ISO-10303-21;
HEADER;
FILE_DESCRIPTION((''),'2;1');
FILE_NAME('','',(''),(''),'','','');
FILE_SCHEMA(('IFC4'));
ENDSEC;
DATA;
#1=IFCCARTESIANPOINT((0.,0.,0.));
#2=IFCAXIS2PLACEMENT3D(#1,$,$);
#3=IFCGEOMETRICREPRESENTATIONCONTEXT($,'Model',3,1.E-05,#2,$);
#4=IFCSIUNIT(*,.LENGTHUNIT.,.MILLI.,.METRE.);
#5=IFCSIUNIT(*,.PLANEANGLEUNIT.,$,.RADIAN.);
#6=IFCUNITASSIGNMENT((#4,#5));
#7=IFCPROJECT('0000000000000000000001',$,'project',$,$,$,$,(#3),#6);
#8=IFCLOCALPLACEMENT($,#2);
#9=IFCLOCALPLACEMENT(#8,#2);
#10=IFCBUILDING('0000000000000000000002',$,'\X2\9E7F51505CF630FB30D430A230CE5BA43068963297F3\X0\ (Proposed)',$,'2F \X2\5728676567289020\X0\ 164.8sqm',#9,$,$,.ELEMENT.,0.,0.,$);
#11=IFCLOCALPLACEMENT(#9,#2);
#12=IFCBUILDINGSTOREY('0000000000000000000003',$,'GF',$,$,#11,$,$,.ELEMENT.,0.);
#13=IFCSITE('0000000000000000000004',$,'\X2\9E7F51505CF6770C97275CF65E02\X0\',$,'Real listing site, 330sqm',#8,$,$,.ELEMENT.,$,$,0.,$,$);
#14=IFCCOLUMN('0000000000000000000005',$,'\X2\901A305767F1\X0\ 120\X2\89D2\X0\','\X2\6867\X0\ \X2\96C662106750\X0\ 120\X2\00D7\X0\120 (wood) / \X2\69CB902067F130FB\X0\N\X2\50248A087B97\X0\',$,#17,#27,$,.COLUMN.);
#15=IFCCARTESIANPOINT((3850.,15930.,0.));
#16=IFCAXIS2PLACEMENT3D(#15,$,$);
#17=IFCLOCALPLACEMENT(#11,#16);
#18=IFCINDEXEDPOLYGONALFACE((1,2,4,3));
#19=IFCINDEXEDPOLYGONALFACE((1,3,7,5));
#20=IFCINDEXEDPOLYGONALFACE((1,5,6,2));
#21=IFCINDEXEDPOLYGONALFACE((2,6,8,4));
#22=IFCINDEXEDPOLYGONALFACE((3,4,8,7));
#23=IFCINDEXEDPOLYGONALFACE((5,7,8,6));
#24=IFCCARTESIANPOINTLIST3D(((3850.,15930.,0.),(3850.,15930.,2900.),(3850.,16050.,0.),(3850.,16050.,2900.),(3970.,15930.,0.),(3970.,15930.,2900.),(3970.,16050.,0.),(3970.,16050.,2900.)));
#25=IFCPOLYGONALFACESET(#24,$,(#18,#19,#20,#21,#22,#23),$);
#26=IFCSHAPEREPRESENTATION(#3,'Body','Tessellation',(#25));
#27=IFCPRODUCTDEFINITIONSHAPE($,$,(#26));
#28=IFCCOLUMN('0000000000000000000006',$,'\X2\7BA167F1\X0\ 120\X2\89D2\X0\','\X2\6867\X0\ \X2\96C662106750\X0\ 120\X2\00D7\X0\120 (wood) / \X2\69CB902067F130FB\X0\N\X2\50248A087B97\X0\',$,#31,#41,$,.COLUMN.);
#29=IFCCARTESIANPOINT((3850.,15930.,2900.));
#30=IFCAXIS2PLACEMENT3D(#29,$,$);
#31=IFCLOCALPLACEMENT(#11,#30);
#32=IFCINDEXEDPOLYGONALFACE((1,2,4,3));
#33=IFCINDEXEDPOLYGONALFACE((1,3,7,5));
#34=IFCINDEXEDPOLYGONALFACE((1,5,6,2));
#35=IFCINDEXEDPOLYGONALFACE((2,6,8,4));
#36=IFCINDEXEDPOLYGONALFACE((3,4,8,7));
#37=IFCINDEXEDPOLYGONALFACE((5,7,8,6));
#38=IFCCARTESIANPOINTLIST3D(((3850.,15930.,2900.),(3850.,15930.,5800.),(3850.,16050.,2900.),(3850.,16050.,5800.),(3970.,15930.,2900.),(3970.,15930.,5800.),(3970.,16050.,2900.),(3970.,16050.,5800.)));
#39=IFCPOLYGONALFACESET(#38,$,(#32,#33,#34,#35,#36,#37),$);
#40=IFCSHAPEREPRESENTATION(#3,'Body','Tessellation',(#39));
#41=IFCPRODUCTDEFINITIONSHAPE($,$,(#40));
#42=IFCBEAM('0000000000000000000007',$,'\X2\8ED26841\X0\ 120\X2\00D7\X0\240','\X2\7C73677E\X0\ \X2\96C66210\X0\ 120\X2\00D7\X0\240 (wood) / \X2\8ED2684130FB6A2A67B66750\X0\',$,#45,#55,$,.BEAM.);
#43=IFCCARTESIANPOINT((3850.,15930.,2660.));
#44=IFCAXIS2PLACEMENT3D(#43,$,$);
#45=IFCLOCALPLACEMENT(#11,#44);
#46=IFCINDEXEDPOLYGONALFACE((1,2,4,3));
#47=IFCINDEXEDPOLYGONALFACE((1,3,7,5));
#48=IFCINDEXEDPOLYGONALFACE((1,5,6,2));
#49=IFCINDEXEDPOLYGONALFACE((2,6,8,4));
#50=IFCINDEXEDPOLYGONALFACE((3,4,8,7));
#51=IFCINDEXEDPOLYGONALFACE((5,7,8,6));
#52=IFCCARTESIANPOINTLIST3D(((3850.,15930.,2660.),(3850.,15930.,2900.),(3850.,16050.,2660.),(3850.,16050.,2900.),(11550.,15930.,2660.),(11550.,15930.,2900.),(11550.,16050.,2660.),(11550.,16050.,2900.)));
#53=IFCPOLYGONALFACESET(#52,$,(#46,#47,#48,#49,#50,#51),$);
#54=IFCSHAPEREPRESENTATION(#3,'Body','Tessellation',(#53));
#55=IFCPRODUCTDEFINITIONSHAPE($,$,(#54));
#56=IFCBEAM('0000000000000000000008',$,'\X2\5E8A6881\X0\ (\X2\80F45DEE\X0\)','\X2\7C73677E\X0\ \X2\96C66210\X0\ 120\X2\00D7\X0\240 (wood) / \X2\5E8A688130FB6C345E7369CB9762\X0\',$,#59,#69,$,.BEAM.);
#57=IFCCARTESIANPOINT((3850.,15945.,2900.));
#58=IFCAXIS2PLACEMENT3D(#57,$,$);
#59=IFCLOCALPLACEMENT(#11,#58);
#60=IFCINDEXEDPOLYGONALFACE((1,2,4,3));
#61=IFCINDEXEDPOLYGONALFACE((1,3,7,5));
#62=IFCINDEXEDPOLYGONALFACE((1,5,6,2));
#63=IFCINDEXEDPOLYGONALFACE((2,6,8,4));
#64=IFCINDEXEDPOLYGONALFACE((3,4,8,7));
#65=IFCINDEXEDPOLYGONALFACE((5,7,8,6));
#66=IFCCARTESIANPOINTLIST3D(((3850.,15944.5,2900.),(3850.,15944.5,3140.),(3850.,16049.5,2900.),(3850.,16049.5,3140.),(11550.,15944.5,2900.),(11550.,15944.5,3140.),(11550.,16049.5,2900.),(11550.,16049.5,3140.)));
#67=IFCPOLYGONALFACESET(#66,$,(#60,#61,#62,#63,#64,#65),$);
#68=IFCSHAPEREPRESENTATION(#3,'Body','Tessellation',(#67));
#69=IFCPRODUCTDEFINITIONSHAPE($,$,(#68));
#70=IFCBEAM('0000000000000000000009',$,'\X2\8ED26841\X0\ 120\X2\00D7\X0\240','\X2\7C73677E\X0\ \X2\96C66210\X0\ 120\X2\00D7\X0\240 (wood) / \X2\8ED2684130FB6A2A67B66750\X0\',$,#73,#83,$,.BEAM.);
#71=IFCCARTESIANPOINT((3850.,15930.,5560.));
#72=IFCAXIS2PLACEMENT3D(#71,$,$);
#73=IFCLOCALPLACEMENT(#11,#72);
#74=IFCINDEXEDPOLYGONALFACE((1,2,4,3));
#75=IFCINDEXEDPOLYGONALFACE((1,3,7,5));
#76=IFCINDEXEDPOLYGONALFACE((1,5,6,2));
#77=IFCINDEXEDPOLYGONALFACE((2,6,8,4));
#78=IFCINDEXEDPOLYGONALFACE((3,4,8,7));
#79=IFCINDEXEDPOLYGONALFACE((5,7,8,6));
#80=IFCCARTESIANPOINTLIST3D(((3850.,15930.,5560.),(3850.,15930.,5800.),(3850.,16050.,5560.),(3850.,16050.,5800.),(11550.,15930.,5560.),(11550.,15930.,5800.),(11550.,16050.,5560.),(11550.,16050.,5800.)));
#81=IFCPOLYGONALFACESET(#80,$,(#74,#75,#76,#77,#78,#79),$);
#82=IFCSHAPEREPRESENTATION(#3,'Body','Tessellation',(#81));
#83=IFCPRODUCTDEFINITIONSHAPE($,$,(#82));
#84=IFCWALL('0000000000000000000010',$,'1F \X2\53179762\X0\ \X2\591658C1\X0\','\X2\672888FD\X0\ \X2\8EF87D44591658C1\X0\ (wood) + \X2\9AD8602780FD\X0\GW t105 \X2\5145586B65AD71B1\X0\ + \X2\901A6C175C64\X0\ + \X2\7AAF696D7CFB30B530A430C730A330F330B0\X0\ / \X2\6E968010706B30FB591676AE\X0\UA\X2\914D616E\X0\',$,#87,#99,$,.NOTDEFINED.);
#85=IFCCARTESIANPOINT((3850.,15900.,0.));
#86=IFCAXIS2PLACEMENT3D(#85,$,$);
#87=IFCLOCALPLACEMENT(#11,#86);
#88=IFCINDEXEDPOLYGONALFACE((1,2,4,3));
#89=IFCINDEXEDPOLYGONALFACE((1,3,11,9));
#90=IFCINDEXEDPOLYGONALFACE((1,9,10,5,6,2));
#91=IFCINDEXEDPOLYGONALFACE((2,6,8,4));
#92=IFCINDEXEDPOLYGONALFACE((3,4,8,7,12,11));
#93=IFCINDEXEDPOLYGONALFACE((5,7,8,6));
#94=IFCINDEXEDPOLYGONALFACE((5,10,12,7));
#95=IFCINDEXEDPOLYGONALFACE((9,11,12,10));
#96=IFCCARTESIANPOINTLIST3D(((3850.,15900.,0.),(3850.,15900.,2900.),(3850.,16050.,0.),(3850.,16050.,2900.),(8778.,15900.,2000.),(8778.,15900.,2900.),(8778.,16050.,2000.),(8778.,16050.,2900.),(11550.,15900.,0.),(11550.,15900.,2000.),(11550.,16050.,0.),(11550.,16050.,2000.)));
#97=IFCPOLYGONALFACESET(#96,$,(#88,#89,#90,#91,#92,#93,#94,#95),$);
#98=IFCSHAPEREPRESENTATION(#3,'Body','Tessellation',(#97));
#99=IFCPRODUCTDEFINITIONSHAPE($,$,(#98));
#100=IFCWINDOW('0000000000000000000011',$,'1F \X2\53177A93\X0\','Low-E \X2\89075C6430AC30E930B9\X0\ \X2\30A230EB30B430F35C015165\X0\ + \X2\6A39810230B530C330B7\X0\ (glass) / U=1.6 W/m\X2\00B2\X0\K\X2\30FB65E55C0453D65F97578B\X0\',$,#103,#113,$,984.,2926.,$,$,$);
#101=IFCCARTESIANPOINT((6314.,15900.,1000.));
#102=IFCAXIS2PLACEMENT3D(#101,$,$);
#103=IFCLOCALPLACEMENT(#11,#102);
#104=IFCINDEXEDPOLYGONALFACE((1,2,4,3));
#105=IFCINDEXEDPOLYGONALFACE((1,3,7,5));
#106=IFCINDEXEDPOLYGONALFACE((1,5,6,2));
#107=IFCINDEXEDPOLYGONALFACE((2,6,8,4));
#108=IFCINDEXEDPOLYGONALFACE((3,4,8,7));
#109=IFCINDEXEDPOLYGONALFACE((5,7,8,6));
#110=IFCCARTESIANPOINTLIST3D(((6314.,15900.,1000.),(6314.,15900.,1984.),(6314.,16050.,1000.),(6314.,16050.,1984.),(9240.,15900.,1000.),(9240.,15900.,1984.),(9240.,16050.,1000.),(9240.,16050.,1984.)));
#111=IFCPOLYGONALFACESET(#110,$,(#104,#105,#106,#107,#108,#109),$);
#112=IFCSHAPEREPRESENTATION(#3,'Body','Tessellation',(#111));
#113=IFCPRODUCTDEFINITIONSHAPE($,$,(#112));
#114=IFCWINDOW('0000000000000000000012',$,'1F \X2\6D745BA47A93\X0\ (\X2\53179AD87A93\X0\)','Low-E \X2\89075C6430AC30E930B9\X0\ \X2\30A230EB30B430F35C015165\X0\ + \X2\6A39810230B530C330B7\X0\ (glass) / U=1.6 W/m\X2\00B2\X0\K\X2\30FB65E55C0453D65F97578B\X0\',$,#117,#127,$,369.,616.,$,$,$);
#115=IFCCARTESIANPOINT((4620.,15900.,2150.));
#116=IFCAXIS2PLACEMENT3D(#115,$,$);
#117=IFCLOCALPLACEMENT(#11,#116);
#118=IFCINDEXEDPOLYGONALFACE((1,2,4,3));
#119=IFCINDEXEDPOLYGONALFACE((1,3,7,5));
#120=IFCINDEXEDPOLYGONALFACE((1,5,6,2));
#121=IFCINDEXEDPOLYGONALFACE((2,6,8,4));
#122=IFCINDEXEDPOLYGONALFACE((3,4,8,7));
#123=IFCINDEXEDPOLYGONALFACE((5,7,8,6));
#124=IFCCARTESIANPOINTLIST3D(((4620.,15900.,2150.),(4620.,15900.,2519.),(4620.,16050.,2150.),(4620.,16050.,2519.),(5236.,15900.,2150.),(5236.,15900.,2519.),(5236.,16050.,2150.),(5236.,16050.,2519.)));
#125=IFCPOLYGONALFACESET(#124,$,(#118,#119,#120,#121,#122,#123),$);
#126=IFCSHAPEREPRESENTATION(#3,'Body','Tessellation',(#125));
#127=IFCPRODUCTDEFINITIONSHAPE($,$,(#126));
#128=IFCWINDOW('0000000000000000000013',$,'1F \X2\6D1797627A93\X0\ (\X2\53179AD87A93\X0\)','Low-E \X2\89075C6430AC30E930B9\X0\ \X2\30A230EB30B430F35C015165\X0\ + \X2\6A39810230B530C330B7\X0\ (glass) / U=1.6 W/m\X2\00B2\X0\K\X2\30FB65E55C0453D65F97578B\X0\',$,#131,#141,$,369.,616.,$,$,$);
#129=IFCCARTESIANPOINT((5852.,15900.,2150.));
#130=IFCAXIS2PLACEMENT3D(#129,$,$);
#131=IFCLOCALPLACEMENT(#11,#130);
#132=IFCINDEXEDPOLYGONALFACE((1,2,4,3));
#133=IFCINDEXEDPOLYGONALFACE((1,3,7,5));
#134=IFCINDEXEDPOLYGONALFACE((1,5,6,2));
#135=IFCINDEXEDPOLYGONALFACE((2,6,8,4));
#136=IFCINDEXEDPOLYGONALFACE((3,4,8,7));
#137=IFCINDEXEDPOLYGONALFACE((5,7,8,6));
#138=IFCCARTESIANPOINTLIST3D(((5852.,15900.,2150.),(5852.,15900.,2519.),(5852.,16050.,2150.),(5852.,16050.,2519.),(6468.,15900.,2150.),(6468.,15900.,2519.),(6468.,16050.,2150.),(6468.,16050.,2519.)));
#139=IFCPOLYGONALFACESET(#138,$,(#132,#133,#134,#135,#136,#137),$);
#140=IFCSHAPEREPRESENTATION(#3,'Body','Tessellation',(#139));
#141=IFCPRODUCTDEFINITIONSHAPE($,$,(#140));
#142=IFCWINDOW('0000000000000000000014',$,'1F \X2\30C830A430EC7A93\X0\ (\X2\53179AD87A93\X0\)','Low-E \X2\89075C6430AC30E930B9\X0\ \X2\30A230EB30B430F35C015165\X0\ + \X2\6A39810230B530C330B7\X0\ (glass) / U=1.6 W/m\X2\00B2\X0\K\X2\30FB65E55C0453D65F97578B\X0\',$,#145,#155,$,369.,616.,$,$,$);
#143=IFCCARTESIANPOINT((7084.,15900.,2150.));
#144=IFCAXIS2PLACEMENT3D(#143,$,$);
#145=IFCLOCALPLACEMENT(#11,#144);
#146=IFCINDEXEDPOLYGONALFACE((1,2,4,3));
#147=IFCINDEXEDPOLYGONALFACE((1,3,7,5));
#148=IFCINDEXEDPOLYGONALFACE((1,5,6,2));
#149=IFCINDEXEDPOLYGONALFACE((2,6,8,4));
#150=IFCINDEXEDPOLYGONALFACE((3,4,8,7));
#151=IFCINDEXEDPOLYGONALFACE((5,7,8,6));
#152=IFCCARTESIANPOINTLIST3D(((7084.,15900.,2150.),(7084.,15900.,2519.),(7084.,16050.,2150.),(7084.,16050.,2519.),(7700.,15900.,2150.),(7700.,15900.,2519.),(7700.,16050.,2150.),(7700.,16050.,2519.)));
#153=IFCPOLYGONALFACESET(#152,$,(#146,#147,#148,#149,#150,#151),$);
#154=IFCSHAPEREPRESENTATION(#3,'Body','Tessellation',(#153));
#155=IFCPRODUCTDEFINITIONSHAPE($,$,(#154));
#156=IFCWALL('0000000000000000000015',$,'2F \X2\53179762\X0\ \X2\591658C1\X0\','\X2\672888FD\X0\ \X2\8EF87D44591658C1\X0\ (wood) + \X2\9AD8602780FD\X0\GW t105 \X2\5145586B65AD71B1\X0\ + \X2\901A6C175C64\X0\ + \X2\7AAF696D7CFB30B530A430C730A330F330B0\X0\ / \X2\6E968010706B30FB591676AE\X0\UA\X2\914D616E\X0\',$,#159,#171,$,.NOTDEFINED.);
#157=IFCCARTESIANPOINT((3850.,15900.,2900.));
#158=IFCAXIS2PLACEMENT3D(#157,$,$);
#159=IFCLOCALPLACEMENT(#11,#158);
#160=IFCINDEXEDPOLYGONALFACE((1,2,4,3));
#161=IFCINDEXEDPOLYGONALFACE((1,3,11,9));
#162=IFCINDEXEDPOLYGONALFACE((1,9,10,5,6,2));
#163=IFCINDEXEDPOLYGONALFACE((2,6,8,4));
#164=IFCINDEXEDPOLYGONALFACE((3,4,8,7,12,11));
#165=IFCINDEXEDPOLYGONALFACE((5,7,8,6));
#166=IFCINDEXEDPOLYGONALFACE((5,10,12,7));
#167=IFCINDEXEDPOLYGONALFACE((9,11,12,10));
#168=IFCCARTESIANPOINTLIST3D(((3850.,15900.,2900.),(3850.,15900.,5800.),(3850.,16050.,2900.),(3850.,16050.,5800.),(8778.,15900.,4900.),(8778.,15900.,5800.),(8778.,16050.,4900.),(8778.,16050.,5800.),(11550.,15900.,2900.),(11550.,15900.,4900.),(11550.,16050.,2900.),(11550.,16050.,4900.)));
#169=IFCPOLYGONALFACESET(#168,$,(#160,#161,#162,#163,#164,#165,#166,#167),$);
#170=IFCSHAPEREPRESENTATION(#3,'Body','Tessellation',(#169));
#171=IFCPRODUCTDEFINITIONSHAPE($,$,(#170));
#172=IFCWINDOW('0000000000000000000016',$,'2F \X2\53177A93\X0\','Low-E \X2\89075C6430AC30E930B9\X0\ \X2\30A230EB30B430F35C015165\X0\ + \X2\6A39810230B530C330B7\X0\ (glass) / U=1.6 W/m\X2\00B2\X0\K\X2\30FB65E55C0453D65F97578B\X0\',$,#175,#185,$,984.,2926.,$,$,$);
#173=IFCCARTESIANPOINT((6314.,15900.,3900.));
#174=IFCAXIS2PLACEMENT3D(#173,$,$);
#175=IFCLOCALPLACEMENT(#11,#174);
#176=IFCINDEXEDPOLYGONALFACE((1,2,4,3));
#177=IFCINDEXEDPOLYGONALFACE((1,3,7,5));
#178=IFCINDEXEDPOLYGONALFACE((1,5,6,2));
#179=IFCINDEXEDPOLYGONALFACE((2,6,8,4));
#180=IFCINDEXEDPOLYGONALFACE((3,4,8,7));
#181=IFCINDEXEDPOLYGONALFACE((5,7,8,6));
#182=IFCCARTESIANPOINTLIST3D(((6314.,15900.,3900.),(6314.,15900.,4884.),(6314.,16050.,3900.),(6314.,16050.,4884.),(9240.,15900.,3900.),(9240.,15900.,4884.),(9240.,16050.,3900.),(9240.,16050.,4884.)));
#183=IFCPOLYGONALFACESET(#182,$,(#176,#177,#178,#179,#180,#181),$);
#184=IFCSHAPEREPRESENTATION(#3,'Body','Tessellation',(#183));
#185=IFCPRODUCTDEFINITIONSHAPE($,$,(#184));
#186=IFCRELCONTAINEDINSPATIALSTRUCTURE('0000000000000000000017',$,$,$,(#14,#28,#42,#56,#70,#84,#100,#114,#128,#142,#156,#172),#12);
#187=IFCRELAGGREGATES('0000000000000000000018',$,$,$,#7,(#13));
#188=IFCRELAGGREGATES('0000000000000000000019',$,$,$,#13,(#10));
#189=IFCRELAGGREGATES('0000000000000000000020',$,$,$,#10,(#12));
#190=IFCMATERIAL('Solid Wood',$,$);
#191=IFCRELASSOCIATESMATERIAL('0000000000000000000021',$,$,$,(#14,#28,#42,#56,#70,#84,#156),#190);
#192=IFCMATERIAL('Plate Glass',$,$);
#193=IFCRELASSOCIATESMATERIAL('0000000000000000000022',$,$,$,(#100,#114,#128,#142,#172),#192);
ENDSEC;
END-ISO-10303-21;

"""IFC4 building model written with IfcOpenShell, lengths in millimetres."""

from ifc_helpers import new_model, si_unit, frame, frame_2d, origin, place, context, project, spatial, rectangle, extrude, material, element, fill, save


model = new_model("IFC4")

# Units and contexts
model_context = context("Model", 3, precision=1e-05, world=origin())
ifc_project = project(units=[si_unit("LENGTHUNIT", "METRE", prefix="MILLI"), si_unit("PLANEANGLEUNIT", "RADIAN")], contexts=[model_context])

# Site, building, storey
site_placement = place(None, origin())
site = spatial("IfcSite", under=ifc_project, at=site_placement, Name="鹿児島県霧島市", ObjectType="Real listing site, 330sqm", CompositionType="ELEMENT", RefElevation=0.0)
building_placement = place(site_placement, origin())
building = spatial("IfcBuilding", under=site, at=building_placement, Name="鹿児島・ピアノ室と防音 (Proposed)", ObjectType="2F 在来木造 164.8sqm", CompositionType="ELEMENT", ElevationOfRefHeight=0.0, ElevationOfTerrain=0.0)
storey_placement = place(building_placement, origin())
storey = spatial("IfcBuildingStorey", under=building, at=storey_placement, Name="GF", CompositionType="ELEMENT", Elevation=0.0)

# Columns
ifc_material_1 = material(Name="Solid Wood")
column_1_placement = place(storey_placement, frame((3850.0, 15930.0, 0.0)))
element("IfcColumn", 1, at=column_1_placement, inside=storey, material=ifc_material_1, Name="通し柱 120角", Description="桧 集成材 120×120 (wood) / 構造柱・N値計算", PredefinedType="COLUMN", context=model_context, shape_type="SweptSolid", body=[
    extrude(rectangle(XDim=120.0, YDim=120.0, at=frame_2d((60.0, 60.0))), frame((3850.0, 15930.0, 0.0)), (0.0, 0.0, 1.0), 2900.0),
])
column_2_placement = place(storey_placement, frame((3850.0, 15930.0, 2900.0)))
element("IfcColumn", 2, at=column_2_placement, inside=storey, material=ifc_material_1, Name="管柱 120角", Description="桧 集成材 120×120 (wood) / 構造柱・N値計算", PredefinedType="COLUMN", context=model_context, shape_type="SweptSolid", body=[
    extrude(rectangle(XDim=120.0, YDim=120.0, at=frame_2d((60.0, 60.0))), frame((3850.0, 15930.0, 2900.0)), (0.0, 0.0, 1.0), 2900.0),
])

# Beams
beam_1_placement = place(storey_placement, frame((3850.0, 15930.0, 2660.0)))
element("IfcBeam", 3, at=beam_1_placement, inside=storey, material=ifc_material_1, Name="軒桁 120×240", Description="米松 集成 120×240 (wood) / 軒桁・横架材", PredefinedType="BEAM", context=model_context, shape_type="SweptSolid", body=[
    extrude(rectangle(XDim=7700.0, YDim=120.0, at=frame_2d((3850.0, 60.0))), frame((3850.0, 15930.0, 2660.0)), (0.0, 0.0, 1.0), 240.0),
])
beam_2_placement = place(storey_placement, frame((3850.0, 15945.0, 2900.0)))
element("IfcBeam", 4, at=beam_2_placement, inside=storey, material=ifc_material_1, Name="床梁 (胴差)", Description="米松 集成 120×240 (wood) / 床梁・水平構面", PredefinedType="BEAM", context=model_context, shape_type="SweptSolid", body=[
    extrude(rectangle(XDim=7700.0, YDim=105.0, at=frame_2d((3850.0, 52.0))), frame((3850.0, 15945.0, 2900.0)), (0.0, 0.0, 1.0), 240.0),
])
beam_3_placement = place(storey_placement, frame((3850.0, 15930.0, 5560.0)))
element("IfcBeam", 5, at=beam_3_placement, inside=storey, material=ifc_material_1, Name="軒桁 120×240", Description="米松 集成 120×240 (wood) / 軒桁・横架材", PredefinedType="BEAM", context=model_context, shape_type="SweptSolid", body=[
    extrude(rectangle(XDim=7700.0, YDim=120.0, at=frame_2d((3850.0, 60.0))), frame((3850.0, 15930.0, 5560.0)), (0.0, 0.0, 1.0), 240.0),
])

# Wall, openings, windows
wall_1_placement = place(storey_placement, frame((3850.0, 15900.0, 0.0)))
wall_1 = element("IfcWall", 6, at=wall_1_placement, inside=storey, material=ifc_material_1, Name="1F 北面 外壁", Description="木製 軸組外壁 (wood) + 高性能GW t105 充填断熱 + 通気層 + 窯業系サイディング / 準耐火・外皮UA配慮", PredefinedType="NOTDEFINED", context=model_context, shape_type="SweptSolid", body=[
    extrude(rectangle(XDim=7700.0, YDim=150.0, at=frame_2d((3850.0, 75.0))), frame((3850.0, 15900.0, 0.0)), (0.0, 0.0, 1.0), 2900.0),
])
opening_1_placement = place(storey_placement, frame((6314.0, 15900.0, 1000.0)))
opening_1 = element("IfcOpeningElement", 7, at=opening_1_placement, cuts=wall_1, PredefinedType="NOTDEFINED", context=model_context, shape_type="SweptSolid", body=[
    extrude(rectangle(XDim=2926.0, YDim=150.0, at=frame_2d((1463.0, 75.0))), frame((6314.0, 15900.0, 1000.0)), (0.0, 0.0, 1.0), 984.0),
])
opening_2_placement = place(storey_placement, frame((4620.0, 15900.0, 2150.0)))
opening_2 = element("IfcOpeningElement", 8, at=opening_2_placement, cuts=wall_1, PredefinedType="NOTDEFINED", context=model_context, shape_type="SweptSolid", body=[
    extrude(rectangle(XDim=616.0, YDim=150.0, at=frame_2d((308.0, 75.0))), frame((4620.0, 15900.0, 2150.0)), (0.0, 0.0, 1.0), 369.0),
])
opening_3_placement = place(storey_placement, frame((5852.0, 15900.0, 2150.0)))
opening_3 = element("IfcOpeningElement", 9, at=opening_3_placement, cuts=wall_1, PredefinedType="NOTDEFINED", context=model_context, shape_type="SweptSolid", body=[
    extrude(rectangle(XDim=616.0, YDim=150.0, at=frame_2d((308.0, 75.0))), frame((5852.0, 15900.0, 2150.0)), (0.0, 0.0, 1.0), 369.0),
])
opening_4_placement = place(storey_placement, frame((7084.0, 15900.0, 2150.0)))
opening_4 = element("IfcOpeningElement", 10, at=opening_4_placement, cuts=wall_1, PredefinedType="NOTDEFINED", context=model_context, shape_type="SweptSolid", body=[
    extrude(rectangle(XDim=616.0, YDim=150.0, at=frame_2d((308.0, 75.0))), frame((7084.0, 15900.0, 2150.0)), (0.0, 0.0, 1.0), 369.0),
])
ifc_material_2 = material(Name="Plate Glass")
window_1_placement = place(storey_placement, frame((6314.0, 15900.0, 1000.0)))
window_1 = element("IfcWindow", 11, at=window_1_placement, inside=storey, material=ifc_material_2, Name="1F 北窓", Description="Low-E 複層ガラス アルゴン封入 + 樹脂サッシ (glass) / U=1.6 W/m²K・日射取得型", OverallHeight=984.0, OverallWidth=2926.0, context=model_context, shape_type="SweptSolid", body=[
    extrude(rectangle(XDim=2926.0, YDim=150.0, at=frame_2d((1463.0, 75.0))), frame((6314.0, 15900.0, 1000.0)), (0.0, 0.0, 1.0), 984.0),
])
fill(opening_1, window_1)
window_2_placement = place(storey_placement, frame((4620.0, 15900.0, 2150.0)))
window_2 = element("IfcWindow", 12, at=window_2_placement, inside=storey, material=ifc_material_2, Name="1F 浴室窓 (北高窓)", Description="Low-E 複層ガラス アルゴン封入 + 樹脂サッシ (glass) / U=1.6 W/m²K・日射取得型", OverallHeight=369.0, OverallWidth=616.0, context=model_context, shape_type="SweptSolid", body=[
    extrude(rectangle(XDim=616.0, YDim=150.0, at=frame_2d((308.0, 75.0))), frame((4620.0, 15900.0, 2150.0)), (0.0, 0.0, 1.0), 369.0),
])
fill(opening_2, window_2)
window_3_placement = place(storey_placement, frame((5852.0, 15900.0, 2150.0)))
window_3 = element("IfcWindow", 13, at=window_3_placement, inside=storey, material=ifc_material_2, Name="1F 洗面窓 (北高窓)", Description="Low-E 複層ガラス アルゴン封入 + 樹脂サッシ (glass) / U=1.6 W/m²K・日射取得型", OverallHeight=369.0, OverallWidth=616.0, context=model_context, shape_type="SweptSolid", body=[
    extrude(rectangle(XDim=616.0, YDim=150.0, at=frame_2d((308.0, 75.0))), frame((5852.0, 15900.0, 2150.0)), (0.0, 0.0, 1.0), 369.0),
])
fill(opening_3, window_3)
window_4_placement = place(storey_placement, frame((7084.0, 15900.0, 2150.0)))
window_4 = element("IfcWindow", 14, at=window_4_placement, inside=storey, material=ifc_material_2, Name="1F トイレ窓 (北高窓)", Description="Low-E 複層ガラス アルゴン封入 + 樹脂サッシ (glass) / U=1.6 W/m²K・日射取得型", OverallHeight=369.0, OverallWidth=616.0, context=model_context, shape_type="SweptSolid", body=[
    extrude(rectangle(XDim=616.0, YDim=150.0, at=frame_2d((308.0, 75.0))), frame((7084.0, 15900.0, 2150.0)), (0.0, 0.0, 1.0), 369.0),
])
fill(opening_4, window_4)

# Wall, opening, window
wall_2_placement = place(storey_placement, frame((3850.0, 15900.0, 2900.0)))
wall_2 = element("IfcWall", 15, at=wall_2_placement, inside=storey, material=ifc_material_1, Name="2F 北面 外壁", Description="木製 軸組外壁 (wood) + 高性能GW t105 充填断熱 + 通気層 + 窯業系サイディング / 準耐火・外皮UA配慮", PredefinedType="NOTDEFINED", context=model_context, shape_type="SweptSolid", body=[
    extrude(rectangle(XDim=7700.0, YDim=150.0, at=frame_2d((3850.0, 75.0))), frame((3850.0, 15900.0, 2900.0)), (0.0, 0.0, 1.0), 2900.0),
])
opening_5_placement = place(storey_placement, frame((6314.0, 15900.0, 3900.0)))
opening_5 = element("IfcOpeningElement", 16, at=opening_5_placement, cuts=wall_2, PredefinedType="NOTDEFINED", context=model_context, shape_type="SweptSolid", body=[
    extrude(rectangle(XDim=2926.0, YDim=150.0, at=frame_2d((1463.0, 75.0))), frame((6314.0, 15900.0, 3900.0)), (0.0, 0.0, 1.0), 984.0),
])
window_5_placement = place(storey_placement, frame((6314.0, 15900.0, 3900.0)))
window_5 = element("IfcWindow", 17, at=window_5_placement, inside=storey, material=ifc_material_2, Name="2F 北窓", Description="Low-E 複層ガラス アルゴン封入 + 樹脂サッシ (glass) / U=1.6 W/m²K・日射取得型", OverallHeight=984.0, OverallWidth=2926.0, context=model_context, shape_type="SweptSolid", body=[
    extrude(rectangle(XDim=2926.0, YDim=150.0, at=frame_2d((1463.0, 75.0))), frame((6314.0, 15900.0, 3900.0)), (0.0, 0.0, 1.0), 984.0),
])
fill(opening_5, window_5)

save(model, "model.ifc")
